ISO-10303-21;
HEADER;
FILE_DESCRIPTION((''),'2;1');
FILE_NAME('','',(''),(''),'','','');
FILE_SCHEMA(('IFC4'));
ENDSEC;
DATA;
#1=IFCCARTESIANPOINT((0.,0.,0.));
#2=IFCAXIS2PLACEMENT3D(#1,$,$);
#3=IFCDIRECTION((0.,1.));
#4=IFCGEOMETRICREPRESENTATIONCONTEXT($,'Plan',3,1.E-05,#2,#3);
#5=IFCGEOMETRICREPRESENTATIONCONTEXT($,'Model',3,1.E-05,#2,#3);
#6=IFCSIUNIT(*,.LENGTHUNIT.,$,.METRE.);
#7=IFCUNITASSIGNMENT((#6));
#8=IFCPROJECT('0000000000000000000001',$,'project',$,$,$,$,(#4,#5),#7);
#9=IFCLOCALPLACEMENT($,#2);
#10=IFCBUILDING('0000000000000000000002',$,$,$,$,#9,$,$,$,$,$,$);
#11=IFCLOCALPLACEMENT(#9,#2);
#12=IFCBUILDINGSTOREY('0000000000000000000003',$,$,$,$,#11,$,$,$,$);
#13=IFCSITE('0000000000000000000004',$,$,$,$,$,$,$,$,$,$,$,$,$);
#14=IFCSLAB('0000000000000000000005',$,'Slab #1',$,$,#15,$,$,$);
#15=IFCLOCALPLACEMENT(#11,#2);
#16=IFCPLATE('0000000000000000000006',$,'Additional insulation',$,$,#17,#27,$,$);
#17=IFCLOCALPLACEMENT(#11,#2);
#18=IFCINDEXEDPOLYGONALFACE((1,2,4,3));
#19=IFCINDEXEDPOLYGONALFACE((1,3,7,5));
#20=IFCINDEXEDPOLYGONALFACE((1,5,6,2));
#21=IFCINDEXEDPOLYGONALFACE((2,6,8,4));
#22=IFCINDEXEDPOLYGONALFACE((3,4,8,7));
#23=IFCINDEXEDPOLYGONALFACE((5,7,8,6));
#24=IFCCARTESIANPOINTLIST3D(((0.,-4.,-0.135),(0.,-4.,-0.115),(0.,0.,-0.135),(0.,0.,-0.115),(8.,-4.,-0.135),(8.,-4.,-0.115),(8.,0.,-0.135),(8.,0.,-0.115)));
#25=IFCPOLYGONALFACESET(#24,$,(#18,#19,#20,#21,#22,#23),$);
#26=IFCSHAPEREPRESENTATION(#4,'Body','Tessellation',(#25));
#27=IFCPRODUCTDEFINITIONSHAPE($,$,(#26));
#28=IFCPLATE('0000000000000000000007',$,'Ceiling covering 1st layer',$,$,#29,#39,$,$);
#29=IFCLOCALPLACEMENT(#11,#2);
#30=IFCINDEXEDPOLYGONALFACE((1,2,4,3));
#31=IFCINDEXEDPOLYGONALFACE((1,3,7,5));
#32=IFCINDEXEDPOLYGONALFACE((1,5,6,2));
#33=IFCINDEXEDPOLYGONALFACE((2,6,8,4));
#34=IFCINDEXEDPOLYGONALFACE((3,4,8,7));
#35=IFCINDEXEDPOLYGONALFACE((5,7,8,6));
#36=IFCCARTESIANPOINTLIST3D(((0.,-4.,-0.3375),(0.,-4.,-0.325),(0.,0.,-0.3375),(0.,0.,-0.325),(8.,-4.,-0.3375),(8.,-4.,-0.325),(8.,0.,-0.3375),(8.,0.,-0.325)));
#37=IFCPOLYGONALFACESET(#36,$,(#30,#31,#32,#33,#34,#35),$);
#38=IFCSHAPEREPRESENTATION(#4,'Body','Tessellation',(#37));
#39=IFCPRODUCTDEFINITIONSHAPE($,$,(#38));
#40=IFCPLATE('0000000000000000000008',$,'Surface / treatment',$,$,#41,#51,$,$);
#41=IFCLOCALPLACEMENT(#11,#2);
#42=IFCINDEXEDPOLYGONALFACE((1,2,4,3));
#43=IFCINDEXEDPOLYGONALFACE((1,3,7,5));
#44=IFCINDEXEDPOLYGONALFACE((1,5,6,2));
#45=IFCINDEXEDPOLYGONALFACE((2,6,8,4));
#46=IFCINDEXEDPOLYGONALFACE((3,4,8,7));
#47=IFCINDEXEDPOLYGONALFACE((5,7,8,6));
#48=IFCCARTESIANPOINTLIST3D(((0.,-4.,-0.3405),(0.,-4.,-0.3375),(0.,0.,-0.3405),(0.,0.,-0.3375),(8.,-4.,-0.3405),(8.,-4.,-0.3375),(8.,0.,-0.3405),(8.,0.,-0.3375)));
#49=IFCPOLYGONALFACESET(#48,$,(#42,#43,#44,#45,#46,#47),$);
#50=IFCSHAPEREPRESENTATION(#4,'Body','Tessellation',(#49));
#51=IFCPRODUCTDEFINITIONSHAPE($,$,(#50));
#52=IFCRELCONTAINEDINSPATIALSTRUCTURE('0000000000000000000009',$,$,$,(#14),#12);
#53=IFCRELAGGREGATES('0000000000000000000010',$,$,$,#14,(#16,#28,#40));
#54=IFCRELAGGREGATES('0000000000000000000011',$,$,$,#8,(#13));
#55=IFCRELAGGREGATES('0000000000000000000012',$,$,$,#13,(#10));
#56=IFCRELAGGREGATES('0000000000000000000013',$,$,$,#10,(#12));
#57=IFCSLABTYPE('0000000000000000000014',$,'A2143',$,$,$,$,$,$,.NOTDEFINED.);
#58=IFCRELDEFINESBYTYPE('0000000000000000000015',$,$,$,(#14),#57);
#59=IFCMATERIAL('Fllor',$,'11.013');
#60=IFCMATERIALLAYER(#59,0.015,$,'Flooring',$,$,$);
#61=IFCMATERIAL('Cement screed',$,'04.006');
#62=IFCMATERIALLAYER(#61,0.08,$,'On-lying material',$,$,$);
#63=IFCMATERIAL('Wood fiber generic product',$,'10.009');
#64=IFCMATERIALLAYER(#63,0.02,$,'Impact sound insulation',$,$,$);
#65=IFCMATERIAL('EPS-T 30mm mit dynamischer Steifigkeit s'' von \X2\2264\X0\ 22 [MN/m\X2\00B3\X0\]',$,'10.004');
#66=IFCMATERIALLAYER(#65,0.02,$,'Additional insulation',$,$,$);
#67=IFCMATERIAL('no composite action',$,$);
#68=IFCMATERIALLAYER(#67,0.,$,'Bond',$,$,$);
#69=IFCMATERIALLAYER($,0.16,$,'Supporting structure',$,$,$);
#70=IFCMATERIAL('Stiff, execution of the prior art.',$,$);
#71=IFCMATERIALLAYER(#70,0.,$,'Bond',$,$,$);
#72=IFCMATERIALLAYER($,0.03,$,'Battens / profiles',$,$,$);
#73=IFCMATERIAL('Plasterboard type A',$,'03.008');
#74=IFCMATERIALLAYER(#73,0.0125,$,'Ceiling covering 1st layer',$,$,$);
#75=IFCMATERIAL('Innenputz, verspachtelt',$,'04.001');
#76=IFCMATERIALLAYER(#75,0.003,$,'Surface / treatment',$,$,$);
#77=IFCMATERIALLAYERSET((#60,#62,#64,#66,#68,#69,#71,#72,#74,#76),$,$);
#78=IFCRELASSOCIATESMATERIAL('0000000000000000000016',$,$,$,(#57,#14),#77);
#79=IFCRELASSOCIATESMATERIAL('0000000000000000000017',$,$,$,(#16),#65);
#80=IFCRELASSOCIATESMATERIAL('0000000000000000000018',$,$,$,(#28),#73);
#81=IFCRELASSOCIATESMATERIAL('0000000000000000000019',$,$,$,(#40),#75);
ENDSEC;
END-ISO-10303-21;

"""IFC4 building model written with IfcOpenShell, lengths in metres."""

from ifc_helpers import new_model, si_unit, direction, frame, frame_2d, origin, place, context, project, spatial, rectangle, extrude, material, layer, layer_set, type_object, element, aggregate, save


model = new_model("IFC4")

# Units and contexts
plan_context = context("Plan", 3, precision=1e-05, world=origin(), true_north=direction((0.0, 1.0)))
model_context = context("Model", 3, precision=1e-05, world=origin(), true_north=direction((0.0, 1.0)))
ifc_project = project(units=[si_unit("LENGTHUNIT", "METRE")], contexts=[plan_context, model_context])

# Site, building, storey
site = spatial("IfcSite", under=ifc_project)
building_placement = place(None, origin())
building = spatial("IfcBuilding", under=site, at=building_placement)
storey_placement = place(building_placement, origin())
storey = spatial("IfcBuildingStorey", under=building, at=storey_placement)

# Slab, plates
ifc_material_1 = material(Name="Fllor", Category="11.013")
ifc_layer_1 = layer(ifc_material_1, 0.015, Name="Flooring")
ifc_material_2 = material(Name="Cement screed", Category="04.006")
ifc_layer_2 = layer(ifc_material_2, 0.08, Name="On-lying material")
ifc_material_3 = material(Name="Wood fiber generic product", Category="10.009")
ifc_layer_3 = layer(ifc_material_3, 0.02, Name="Impact sound insulation")
ifc_material_4 = material(Name="EPS-T 30mm mit dynamischer Steifigkeit s' von ≤ 22 [MN/m³]", Category="10.004")
ifc_layer_4 = layer(ifc_material_4, 0.02, Name="Additional insulation")
ifc_material_5 = material(Name="no composite action")
ifc_layer_5 = layer(ifc_material_5, 0.0, Name="Bond")
ifc_layer_6 = layer(None, 0.16, Name="Supporting structure")
ifc_material_6 = material(Name="Stiff, execution of the prior art.")
ifc_layer_7 = layer(ifc_material_6, 0.0, Name="Bond")
ifc_layer_8 = layer(None, 0.03, Name="Battens / profiles")
ifc_material_7 = material(Name="Plasterboard type A", Category="03.008")
ifc_layer_9 = layer(ifc_material_7, 0.0125, Name="Ceiling covering 1st layer")
ifc_material_8 = material(Name="Innenputz, verspachtelt", Category="04.001")
ifc_layer_10 = layer(ifc_material_8, 0.003, Name="Surface / treatment")
ifc_layer_set = layer_set([ifc_layer_1, ifc_layer_2, ifc_layer_3, ifc_layer_4, ifc_layer_5, ifc_layer_6, ifc_layer_7, ifc_layer_8, ifc_layer_9, ifc_layer_10])
slab_type = type_object("IfcSlabType", Name="A2143", PredefinedType="NOTDEFINED", material=ifc_layer_set)
slab_placement = place(None, frame((0.0, 0.0, 0.0), z_axis=(0.0, 0.0, -1.0), x_axis=(1.0, 0.0, 0.0)))
slab = element("IfcSlab", 1, at=slab_placement, inside=storey, type_object=slab_type, material=ifc_layer_set, Name="Slab #1")
plate_1_placement = place(slab_placement, origin())
plate_1 = element("IfcPlate", 2, at=plate_1_placement, material=ifc_material_4, Name="Additional insulation", context=plan_context, shape_type="SweptSolid", body=[
    extrude(rectangle(XDim=8.0, YDim=4.0, at=frame_2d((4.0, 2.0), x_axis=(1.0, 0.0))), frame((0.0, 0.0, 0.115), z_axis=(0.0, 0.0, 1.0), x_axis=(1.0, 0.0, 0.0)), (0.0, 0.0, 1.0), 0.02),
])
plate_2_placement = place(slab_placement, origin())
plate_2 = element("IfcPlate", 3, at=plate_2_placement, material=ifc_material_7, Name="Ceiling covering 1st layer", context=plan_context, shape_type="SweptSolid", body=[
    extrude(rectangle(XDim=8.0, YDim=4.0, at=frame_2d((4.0, 2.0), x_axis=(1.0, 0.0))), frame((0.0, 0.0, 0.325), z_axis=(0.0, 0.0, 1.0), x_axis=(1.0, 0.0, 0.0)), (0.0, 0.0, 1.0), 0.0125),
])
plate_3_placement = place(slab_placement, origin())
plate_3 = element("IfcPlate", 4, at=plate_3_placement, material=ifc_material_8, Name="Surface / treatment", context=plan_context, shape_type="SweptSolid", body=[
    extrude(rectangle(XDim=8.0, YDim=4.0, at=frame_2d((4.0, 2.0), x_axis=(1.0, 0.0))), frame((0.0, 0.0, 0.3375), z_axis=(0.0, 0.0, 1.0), x_axis=(1.0, 0.0, 0.0)), (0.0, 0.0, 1.0), 0.003),
])
aggregate(slab, [plate_1, plate_2, plate_3])

save(model, "model.ifc")
